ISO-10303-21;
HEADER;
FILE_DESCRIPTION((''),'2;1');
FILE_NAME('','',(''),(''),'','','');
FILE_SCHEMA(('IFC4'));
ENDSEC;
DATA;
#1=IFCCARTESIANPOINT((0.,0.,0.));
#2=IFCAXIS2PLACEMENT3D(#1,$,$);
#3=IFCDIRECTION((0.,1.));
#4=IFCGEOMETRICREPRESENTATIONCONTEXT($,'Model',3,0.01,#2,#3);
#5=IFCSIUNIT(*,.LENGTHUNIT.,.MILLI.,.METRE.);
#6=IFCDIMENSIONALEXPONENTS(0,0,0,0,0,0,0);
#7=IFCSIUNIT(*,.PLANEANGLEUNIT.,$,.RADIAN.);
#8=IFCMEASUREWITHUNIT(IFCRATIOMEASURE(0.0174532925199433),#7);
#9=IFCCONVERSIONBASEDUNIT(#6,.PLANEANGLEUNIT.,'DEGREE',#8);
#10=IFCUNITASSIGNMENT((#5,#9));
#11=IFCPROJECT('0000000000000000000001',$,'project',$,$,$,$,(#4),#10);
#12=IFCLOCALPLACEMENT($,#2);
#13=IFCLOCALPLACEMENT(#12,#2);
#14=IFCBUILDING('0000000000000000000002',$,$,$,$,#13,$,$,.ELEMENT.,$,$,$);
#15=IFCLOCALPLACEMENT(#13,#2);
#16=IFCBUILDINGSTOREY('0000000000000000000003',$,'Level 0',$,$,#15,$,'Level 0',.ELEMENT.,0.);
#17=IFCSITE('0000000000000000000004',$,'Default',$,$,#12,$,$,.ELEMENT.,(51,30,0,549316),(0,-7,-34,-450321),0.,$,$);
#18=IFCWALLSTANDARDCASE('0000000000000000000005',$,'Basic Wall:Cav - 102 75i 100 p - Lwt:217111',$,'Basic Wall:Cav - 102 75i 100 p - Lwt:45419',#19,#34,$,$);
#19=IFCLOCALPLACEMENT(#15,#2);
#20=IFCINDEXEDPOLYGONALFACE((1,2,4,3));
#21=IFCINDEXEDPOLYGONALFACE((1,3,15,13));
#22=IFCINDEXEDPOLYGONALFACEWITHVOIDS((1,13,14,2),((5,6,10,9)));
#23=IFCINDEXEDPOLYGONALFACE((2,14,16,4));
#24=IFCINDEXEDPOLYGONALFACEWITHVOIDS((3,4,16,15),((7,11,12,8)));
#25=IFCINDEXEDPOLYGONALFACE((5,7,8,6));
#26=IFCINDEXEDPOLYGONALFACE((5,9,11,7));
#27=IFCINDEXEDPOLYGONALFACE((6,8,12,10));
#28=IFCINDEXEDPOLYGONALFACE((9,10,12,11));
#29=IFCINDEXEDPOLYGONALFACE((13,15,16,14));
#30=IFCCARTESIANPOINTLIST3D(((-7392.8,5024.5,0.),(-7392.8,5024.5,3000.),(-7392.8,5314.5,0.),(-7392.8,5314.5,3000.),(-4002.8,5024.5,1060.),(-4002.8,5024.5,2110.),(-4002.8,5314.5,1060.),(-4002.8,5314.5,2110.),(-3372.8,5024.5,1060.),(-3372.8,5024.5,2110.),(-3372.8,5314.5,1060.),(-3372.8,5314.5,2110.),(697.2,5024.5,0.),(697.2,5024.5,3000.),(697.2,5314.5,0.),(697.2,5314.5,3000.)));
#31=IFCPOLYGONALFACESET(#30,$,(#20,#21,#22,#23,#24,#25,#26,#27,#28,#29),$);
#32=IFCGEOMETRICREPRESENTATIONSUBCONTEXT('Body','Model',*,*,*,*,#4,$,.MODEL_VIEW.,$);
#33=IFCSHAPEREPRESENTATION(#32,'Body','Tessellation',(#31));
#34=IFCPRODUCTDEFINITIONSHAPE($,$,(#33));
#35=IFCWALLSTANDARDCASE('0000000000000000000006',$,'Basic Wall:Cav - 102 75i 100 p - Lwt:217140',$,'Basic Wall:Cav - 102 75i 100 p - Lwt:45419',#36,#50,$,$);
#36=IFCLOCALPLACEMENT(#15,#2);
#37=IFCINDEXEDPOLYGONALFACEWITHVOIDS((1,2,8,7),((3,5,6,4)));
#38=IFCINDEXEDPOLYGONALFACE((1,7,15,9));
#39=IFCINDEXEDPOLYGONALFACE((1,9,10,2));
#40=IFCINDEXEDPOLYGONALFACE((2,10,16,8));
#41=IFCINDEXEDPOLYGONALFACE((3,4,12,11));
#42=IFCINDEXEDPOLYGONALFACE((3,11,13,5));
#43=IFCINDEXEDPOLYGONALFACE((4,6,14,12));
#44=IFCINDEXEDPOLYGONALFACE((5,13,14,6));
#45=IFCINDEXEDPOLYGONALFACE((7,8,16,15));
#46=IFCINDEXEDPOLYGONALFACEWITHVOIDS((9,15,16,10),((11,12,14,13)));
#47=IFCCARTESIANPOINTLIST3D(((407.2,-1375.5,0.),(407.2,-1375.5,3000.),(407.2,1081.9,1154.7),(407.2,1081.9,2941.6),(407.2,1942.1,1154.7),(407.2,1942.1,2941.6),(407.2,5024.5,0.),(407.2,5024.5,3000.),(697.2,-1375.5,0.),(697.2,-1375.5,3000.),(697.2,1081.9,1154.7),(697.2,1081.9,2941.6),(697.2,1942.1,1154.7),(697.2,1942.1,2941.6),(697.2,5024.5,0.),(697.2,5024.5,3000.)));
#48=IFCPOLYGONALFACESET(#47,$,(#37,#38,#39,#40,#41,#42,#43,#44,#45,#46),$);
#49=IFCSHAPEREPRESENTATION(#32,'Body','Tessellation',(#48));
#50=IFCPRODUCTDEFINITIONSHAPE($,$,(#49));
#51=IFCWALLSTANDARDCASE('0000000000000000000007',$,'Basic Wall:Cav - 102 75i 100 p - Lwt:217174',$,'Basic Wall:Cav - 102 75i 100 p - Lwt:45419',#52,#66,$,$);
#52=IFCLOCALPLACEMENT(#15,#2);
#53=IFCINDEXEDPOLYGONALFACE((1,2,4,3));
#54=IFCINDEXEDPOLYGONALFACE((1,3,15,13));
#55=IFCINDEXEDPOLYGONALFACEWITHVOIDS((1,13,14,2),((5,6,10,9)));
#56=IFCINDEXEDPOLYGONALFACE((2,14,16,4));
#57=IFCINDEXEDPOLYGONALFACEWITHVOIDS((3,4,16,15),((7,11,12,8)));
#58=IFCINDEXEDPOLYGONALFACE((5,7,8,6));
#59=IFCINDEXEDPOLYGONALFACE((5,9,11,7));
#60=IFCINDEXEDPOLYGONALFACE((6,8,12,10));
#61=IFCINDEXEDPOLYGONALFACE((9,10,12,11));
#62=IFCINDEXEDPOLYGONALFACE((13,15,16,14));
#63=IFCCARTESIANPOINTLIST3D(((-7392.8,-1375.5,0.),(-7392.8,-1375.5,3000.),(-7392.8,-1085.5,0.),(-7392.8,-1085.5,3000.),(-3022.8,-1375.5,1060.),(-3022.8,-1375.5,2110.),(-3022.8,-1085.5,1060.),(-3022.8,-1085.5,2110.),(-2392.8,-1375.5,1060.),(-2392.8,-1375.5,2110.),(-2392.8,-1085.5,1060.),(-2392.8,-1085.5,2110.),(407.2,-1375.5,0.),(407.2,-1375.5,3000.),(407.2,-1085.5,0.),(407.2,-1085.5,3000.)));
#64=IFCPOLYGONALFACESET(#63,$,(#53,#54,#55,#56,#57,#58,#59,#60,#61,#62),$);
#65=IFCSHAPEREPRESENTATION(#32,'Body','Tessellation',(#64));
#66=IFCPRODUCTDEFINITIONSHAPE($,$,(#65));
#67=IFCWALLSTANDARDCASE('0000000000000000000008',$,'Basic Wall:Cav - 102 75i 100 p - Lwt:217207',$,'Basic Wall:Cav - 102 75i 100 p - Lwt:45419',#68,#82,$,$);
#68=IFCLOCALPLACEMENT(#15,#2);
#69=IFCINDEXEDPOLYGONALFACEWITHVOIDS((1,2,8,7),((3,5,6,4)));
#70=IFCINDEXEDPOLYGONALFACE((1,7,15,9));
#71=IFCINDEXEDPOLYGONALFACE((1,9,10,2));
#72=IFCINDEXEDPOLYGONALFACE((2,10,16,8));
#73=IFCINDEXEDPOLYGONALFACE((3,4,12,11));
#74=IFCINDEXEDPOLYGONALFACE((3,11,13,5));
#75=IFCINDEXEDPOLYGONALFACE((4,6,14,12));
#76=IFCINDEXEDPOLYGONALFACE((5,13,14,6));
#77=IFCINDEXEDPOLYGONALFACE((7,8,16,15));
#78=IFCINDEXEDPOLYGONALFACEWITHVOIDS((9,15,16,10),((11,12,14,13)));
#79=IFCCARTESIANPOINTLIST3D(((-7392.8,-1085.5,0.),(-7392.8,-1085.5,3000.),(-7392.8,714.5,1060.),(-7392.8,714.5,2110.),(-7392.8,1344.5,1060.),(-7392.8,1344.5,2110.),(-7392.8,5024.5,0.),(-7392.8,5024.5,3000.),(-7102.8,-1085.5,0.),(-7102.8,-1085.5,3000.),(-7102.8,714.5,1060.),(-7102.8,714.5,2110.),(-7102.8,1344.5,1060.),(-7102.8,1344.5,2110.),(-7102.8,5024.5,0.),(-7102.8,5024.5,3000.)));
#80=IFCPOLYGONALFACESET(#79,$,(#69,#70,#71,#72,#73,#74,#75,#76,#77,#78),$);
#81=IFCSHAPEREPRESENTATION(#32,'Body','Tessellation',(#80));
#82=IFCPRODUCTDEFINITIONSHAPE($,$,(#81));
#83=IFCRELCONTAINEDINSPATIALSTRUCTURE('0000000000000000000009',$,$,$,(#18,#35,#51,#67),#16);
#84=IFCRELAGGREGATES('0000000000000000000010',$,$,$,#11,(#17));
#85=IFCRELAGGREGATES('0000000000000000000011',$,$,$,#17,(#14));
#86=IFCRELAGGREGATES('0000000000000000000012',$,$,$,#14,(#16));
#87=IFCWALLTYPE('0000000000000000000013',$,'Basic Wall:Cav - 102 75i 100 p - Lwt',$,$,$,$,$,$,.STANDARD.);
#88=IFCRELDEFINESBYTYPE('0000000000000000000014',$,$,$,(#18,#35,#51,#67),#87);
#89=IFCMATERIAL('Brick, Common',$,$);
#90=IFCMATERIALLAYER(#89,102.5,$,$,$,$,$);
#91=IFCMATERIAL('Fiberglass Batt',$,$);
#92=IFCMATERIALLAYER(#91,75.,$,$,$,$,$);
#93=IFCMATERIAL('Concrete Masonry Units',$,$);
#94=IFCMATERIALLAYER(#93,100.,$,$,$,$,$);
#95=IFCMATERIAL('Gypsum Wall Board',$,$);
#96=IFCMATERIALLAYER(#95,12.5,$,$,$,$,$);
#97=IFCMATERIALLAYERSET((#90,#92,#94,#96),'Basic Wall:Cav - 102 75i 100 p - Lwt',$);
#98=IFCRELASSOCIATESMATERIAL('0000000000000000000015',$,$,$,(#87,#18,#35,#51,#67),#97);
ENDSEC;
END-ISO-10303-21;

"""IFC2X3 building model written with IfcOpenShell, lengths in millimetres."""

from ifc_helpers import new_model, entity, si_unit, converted_unit, direction, frame, frame_2d, origin, origin_2d_with_axis, place, context, subcontext, project, spatial, rectangle, extrude, material, layer, layer_set, layer_usage, type_object, element, save


model = new_model("IFC2X3")

# Units and contexts
model_context = context("Model", 3, precision=0.01, world=origin(), true_north=direction((0.0, 1.0)))
body_context = subcontext(model_context, "Body", "Model", "MODEL_VIEW")
ifc_project = project(units=[si_unit("LENGTHUNIT", "METRE", prefix="MILLI"), converted_unit("PLANEANGLEUNIT", "DEGREE", entity("IfcRatioMeasure", 0.0174532925199433), si_unit("PLANEANGLEUNIT", "RADIAN"), dimensions=[0, 0, 0, 0, 0, 0, 0])], contexts=[model_context])

# Site, building, storey
site_placement = place(None, origin())
site = spatial("IfcSite", under=ifc_project, at=site_placement, Name="Default", CompositionType="ELEMENT", RefLatitude=(51, 30, 0, 549316), RefLongitude=(0, -7, -34, -450321), RefElevation=0.0)
building_placement = place(site_placement, origin())
building = spatial("IfcBuilding", under=site, at=building_placement, CompositionType="ELEMENT")
storey_placement = place(building_placement, origin())
storey = spatial("IfcBuildingStorey", under=building, at=storey_placement, Name="Level 0", LongName="Level 0", CompositionType="ELEMENT", Elevation=0.0)

# Walls, openings
ifc_material_1 = material(Name="Brick, Common")
ifc_layer_1 = layer(ifc_material_1, 102.5)
ifc_material_2 = material(Name="Fiberglass Batt")
ifc_layer_2 = layer(ifc_material_2, 75.0)
ifc_material_3 = material(Name="Concrete Masonry Units")
ifc_layer_3 = layer(ifc_material_3, 100.0)
ifc_material_4 = material(Name="Gypsum Wall Board")
ifc_layer_4 = layer(ifc_material_4, 12.5)
ifc_layer_set = layer_set([ifc_layer_1, ifc_layer_2, ifc_layer_3, ifc_layer_4], Name="Basic Wall:Cav - 102 75i 100 p - Lwt")
ifc_layer_usage_1 = layer_usage(ifc_layer_set, "AXIS2", "NEGATIVE", 145.0)
wall_type = type_object("IfcWallType", Name="Basic Wall:Cav - 102 75i 100 p - Lwt", PredefinedType="STANDARD", material=ifc_layer_set)
wall_1_placement = place(storey_placement, frame((-7392.8, 5169.5, 0.0)))
wall_1 = element("IfcWallStandardCase", 1, at=wall_1_placement, inside=storey, type_object=wall_type, material=ifc_layer_usage_1, Name="Basic Wall:Cav - 102 75i 100 p - Lwt:217111", ObjectType="Basic Wall:Cav - 102 75i 100 p - Lwt:45419", context=body_context, shape_type="SweptSolid", body=[
    extrude(rectangle(XDim=8090.0, YDim=290.0, at=frame_2d((4045.0, 0.0), x_axis=(-1.0, 0.0))), origin(), (0.0, 0.0, 1.0), 3000.0),
])
opening_1_placement = place(wall_1_placement, frame((4020.0, 145.0, 1060.0)))
element("IfcOpeningElement", 2, at=opening_1_placement, cuts=wall_1, ObjectType="Opening", context=body_context, shape_type="SweptSolid", body=[
    extrude(rectangle(XDim=1050.0, YDim=630.0, at=frame_2d((525.0, 315.0), x_axis=(-1.0, 0.0))), frame((0.0, 0.0, 0.0), z_axis=(0.0, -1.0, 0.0), x_axis=(0.0, 0.0, 1.0)), (0.0, 0.0, 1.0), 290.0),
])
ifc_layer_usage_2 = layer_usage(ifc_layer_set, "AXIS2", "NEGATIVE", 145.0)
wall_2_placement = place(storey_placement, frame((552.2, 5024.5, 0.0), z_axis=(0.0, 0.0, 1.0), x_axis=(0.0, -1.0, 0.0)))
wall_2 = element("IfcWallStandardCase", 3, at=wall_2_placement, inside=storey, type_object=wall_type, material=ifc_layer_usage_2, Name="Basic Wall:Cav - 102 75i 100 p - Lwt:217140", ObjectType="Basic Wall:Cav - 102 75i 100 p - Lwt:45419", context=body_context, shape_type="SweptSolid", body=[
    extrude(rectangle(XDim=6400.0, YDim=290.0, at=frame_2d((3200.0, 0.0), x_axis=(-1.0, 0.0))), origin(), (0.0, 0.0, 1.0), 3000.0),
])
opening_2_placement = place(wall_2_placement, frame((3942.5, -145.0, 1154.7)))
element("IfcOpeningElement", 4, at=opening_2_placement, cuts=wall_2, ObjectType="Opening", context=body_context, shape_type="SweptSolid", body=[
    extrude(rectangle(XDim=1786.8, YDim=860.1, at=origin_2d_with_axis()), frame((-430.1, 0.0, 893.4), z_axis=(0.0, 1.0, 0.0), x_axis=(0.0, 0.0, -1.0)), (0.0, 0.0, 1.0), 290.0),
])
ifc_layer_usage_3 = layer_usage(ifc_layer_set, "AXIS2", "NEGATIVE", 145.0)
wall_3_placement = place(storey_placement, frame((407.2, -1230.5, 0.0), z_axis=(0.0, 0.0, 1.0), x_axis=(-1.0, 0.0, 0.0)))
wall_3 = element("IfcWallStandardCase", 5, at=wall_3_placement, inside=storey, type_object=wall_type, material=ifc_layer_usage_3, Name="Basic Wall:Cav - 102 75i 100 p - Lwt:217174", ObjectType="Basic Wall:Cav - 102 75i 100 p - Lwt:45419", context=body_context, shape_type="SweptSolid", body=[
    extrude(rectangle(XDim=7800.0, YDim=290.0, at=frame_2d((3900.0, 0.0), x_axis=(-1.0, 0.0))), origin(), (0.0, 0.0, 1.0), 3000.0),
])
opening_3_placement = place(wall_3_placement, frame((2800.0, -145.0, 1060.0)))
element("IfcOpeningElement", 6, at=opening_3_placement, cuts=wall_3, ObjectType="Opening", context=body_context, shape_type="SweptSolid", body=[
    extrude(rectangle(XDim=1050.0, YDim=630.0, at=frame_2d((525.0, 315.0), x_axis=(-1.0, 0.0))), frame((0.0, 0.0, 0.0), z_axis=(0.0, 1.0, 0.0), x_axis=(0.0, 0.0, 1.0)), (0.0, 0.0, 1.0), 290.0),
])
ifc_layer_usage_4 = layer_usage(ifc_layer_set, "AXIS2", "NEGATIVE", 145.0)
wall_4_placement = place(storey_placement, frame((-7247.8, -1085.5, 0.0), z_axis=(0.0, 0.0, 1.0), x_axis=(0.0, 1.0, 0.0)))
wall_4 = element("IfcWallStandardCase", 7, at=wall_4_placement, inside=storey, type_object=wall_type, material=ifc_layer_usage_4, Name="Basic Wall:Cav - 102 75i 100 p - Lwt:217207", ObjectType="Basic Wall:Cav - 102 75i 100 p - Lwt:45419", context=body_context, shape_type="SweptSolid", body=[
    extrude(rectangle(XDim=6110.0, YDim=290.0, at=frame_2d((3055.0, 0.0), x_axis=(-1.0, 0.0))), origin(), (0.0, 0.0, 1.0), 3000.0),
])
opening_4_placement = place(wall_4_placement, frame((1800.0, -145.0, 1060.0)))
element("IfcOpeningElement", 8, at=opening_4_placement, cuts=wall_4, ObjectType="Opening", context=body_context, shape_type="SweptSolid", body=[
    extrude(rectangle(XDim=1050.0, YDim=630.0, at=frame_2d((525.0, 315.0), x_axis=(-1.0, 0.0))), frame((0.0, 0.0, 0.0), z_axis=(0.0, 1.0, 0.0), x_axis=(0.0, 0.0, 1.0)), (0.0, 0.0, 1.0), 290.0),
])

save(model, "model.ifc")
